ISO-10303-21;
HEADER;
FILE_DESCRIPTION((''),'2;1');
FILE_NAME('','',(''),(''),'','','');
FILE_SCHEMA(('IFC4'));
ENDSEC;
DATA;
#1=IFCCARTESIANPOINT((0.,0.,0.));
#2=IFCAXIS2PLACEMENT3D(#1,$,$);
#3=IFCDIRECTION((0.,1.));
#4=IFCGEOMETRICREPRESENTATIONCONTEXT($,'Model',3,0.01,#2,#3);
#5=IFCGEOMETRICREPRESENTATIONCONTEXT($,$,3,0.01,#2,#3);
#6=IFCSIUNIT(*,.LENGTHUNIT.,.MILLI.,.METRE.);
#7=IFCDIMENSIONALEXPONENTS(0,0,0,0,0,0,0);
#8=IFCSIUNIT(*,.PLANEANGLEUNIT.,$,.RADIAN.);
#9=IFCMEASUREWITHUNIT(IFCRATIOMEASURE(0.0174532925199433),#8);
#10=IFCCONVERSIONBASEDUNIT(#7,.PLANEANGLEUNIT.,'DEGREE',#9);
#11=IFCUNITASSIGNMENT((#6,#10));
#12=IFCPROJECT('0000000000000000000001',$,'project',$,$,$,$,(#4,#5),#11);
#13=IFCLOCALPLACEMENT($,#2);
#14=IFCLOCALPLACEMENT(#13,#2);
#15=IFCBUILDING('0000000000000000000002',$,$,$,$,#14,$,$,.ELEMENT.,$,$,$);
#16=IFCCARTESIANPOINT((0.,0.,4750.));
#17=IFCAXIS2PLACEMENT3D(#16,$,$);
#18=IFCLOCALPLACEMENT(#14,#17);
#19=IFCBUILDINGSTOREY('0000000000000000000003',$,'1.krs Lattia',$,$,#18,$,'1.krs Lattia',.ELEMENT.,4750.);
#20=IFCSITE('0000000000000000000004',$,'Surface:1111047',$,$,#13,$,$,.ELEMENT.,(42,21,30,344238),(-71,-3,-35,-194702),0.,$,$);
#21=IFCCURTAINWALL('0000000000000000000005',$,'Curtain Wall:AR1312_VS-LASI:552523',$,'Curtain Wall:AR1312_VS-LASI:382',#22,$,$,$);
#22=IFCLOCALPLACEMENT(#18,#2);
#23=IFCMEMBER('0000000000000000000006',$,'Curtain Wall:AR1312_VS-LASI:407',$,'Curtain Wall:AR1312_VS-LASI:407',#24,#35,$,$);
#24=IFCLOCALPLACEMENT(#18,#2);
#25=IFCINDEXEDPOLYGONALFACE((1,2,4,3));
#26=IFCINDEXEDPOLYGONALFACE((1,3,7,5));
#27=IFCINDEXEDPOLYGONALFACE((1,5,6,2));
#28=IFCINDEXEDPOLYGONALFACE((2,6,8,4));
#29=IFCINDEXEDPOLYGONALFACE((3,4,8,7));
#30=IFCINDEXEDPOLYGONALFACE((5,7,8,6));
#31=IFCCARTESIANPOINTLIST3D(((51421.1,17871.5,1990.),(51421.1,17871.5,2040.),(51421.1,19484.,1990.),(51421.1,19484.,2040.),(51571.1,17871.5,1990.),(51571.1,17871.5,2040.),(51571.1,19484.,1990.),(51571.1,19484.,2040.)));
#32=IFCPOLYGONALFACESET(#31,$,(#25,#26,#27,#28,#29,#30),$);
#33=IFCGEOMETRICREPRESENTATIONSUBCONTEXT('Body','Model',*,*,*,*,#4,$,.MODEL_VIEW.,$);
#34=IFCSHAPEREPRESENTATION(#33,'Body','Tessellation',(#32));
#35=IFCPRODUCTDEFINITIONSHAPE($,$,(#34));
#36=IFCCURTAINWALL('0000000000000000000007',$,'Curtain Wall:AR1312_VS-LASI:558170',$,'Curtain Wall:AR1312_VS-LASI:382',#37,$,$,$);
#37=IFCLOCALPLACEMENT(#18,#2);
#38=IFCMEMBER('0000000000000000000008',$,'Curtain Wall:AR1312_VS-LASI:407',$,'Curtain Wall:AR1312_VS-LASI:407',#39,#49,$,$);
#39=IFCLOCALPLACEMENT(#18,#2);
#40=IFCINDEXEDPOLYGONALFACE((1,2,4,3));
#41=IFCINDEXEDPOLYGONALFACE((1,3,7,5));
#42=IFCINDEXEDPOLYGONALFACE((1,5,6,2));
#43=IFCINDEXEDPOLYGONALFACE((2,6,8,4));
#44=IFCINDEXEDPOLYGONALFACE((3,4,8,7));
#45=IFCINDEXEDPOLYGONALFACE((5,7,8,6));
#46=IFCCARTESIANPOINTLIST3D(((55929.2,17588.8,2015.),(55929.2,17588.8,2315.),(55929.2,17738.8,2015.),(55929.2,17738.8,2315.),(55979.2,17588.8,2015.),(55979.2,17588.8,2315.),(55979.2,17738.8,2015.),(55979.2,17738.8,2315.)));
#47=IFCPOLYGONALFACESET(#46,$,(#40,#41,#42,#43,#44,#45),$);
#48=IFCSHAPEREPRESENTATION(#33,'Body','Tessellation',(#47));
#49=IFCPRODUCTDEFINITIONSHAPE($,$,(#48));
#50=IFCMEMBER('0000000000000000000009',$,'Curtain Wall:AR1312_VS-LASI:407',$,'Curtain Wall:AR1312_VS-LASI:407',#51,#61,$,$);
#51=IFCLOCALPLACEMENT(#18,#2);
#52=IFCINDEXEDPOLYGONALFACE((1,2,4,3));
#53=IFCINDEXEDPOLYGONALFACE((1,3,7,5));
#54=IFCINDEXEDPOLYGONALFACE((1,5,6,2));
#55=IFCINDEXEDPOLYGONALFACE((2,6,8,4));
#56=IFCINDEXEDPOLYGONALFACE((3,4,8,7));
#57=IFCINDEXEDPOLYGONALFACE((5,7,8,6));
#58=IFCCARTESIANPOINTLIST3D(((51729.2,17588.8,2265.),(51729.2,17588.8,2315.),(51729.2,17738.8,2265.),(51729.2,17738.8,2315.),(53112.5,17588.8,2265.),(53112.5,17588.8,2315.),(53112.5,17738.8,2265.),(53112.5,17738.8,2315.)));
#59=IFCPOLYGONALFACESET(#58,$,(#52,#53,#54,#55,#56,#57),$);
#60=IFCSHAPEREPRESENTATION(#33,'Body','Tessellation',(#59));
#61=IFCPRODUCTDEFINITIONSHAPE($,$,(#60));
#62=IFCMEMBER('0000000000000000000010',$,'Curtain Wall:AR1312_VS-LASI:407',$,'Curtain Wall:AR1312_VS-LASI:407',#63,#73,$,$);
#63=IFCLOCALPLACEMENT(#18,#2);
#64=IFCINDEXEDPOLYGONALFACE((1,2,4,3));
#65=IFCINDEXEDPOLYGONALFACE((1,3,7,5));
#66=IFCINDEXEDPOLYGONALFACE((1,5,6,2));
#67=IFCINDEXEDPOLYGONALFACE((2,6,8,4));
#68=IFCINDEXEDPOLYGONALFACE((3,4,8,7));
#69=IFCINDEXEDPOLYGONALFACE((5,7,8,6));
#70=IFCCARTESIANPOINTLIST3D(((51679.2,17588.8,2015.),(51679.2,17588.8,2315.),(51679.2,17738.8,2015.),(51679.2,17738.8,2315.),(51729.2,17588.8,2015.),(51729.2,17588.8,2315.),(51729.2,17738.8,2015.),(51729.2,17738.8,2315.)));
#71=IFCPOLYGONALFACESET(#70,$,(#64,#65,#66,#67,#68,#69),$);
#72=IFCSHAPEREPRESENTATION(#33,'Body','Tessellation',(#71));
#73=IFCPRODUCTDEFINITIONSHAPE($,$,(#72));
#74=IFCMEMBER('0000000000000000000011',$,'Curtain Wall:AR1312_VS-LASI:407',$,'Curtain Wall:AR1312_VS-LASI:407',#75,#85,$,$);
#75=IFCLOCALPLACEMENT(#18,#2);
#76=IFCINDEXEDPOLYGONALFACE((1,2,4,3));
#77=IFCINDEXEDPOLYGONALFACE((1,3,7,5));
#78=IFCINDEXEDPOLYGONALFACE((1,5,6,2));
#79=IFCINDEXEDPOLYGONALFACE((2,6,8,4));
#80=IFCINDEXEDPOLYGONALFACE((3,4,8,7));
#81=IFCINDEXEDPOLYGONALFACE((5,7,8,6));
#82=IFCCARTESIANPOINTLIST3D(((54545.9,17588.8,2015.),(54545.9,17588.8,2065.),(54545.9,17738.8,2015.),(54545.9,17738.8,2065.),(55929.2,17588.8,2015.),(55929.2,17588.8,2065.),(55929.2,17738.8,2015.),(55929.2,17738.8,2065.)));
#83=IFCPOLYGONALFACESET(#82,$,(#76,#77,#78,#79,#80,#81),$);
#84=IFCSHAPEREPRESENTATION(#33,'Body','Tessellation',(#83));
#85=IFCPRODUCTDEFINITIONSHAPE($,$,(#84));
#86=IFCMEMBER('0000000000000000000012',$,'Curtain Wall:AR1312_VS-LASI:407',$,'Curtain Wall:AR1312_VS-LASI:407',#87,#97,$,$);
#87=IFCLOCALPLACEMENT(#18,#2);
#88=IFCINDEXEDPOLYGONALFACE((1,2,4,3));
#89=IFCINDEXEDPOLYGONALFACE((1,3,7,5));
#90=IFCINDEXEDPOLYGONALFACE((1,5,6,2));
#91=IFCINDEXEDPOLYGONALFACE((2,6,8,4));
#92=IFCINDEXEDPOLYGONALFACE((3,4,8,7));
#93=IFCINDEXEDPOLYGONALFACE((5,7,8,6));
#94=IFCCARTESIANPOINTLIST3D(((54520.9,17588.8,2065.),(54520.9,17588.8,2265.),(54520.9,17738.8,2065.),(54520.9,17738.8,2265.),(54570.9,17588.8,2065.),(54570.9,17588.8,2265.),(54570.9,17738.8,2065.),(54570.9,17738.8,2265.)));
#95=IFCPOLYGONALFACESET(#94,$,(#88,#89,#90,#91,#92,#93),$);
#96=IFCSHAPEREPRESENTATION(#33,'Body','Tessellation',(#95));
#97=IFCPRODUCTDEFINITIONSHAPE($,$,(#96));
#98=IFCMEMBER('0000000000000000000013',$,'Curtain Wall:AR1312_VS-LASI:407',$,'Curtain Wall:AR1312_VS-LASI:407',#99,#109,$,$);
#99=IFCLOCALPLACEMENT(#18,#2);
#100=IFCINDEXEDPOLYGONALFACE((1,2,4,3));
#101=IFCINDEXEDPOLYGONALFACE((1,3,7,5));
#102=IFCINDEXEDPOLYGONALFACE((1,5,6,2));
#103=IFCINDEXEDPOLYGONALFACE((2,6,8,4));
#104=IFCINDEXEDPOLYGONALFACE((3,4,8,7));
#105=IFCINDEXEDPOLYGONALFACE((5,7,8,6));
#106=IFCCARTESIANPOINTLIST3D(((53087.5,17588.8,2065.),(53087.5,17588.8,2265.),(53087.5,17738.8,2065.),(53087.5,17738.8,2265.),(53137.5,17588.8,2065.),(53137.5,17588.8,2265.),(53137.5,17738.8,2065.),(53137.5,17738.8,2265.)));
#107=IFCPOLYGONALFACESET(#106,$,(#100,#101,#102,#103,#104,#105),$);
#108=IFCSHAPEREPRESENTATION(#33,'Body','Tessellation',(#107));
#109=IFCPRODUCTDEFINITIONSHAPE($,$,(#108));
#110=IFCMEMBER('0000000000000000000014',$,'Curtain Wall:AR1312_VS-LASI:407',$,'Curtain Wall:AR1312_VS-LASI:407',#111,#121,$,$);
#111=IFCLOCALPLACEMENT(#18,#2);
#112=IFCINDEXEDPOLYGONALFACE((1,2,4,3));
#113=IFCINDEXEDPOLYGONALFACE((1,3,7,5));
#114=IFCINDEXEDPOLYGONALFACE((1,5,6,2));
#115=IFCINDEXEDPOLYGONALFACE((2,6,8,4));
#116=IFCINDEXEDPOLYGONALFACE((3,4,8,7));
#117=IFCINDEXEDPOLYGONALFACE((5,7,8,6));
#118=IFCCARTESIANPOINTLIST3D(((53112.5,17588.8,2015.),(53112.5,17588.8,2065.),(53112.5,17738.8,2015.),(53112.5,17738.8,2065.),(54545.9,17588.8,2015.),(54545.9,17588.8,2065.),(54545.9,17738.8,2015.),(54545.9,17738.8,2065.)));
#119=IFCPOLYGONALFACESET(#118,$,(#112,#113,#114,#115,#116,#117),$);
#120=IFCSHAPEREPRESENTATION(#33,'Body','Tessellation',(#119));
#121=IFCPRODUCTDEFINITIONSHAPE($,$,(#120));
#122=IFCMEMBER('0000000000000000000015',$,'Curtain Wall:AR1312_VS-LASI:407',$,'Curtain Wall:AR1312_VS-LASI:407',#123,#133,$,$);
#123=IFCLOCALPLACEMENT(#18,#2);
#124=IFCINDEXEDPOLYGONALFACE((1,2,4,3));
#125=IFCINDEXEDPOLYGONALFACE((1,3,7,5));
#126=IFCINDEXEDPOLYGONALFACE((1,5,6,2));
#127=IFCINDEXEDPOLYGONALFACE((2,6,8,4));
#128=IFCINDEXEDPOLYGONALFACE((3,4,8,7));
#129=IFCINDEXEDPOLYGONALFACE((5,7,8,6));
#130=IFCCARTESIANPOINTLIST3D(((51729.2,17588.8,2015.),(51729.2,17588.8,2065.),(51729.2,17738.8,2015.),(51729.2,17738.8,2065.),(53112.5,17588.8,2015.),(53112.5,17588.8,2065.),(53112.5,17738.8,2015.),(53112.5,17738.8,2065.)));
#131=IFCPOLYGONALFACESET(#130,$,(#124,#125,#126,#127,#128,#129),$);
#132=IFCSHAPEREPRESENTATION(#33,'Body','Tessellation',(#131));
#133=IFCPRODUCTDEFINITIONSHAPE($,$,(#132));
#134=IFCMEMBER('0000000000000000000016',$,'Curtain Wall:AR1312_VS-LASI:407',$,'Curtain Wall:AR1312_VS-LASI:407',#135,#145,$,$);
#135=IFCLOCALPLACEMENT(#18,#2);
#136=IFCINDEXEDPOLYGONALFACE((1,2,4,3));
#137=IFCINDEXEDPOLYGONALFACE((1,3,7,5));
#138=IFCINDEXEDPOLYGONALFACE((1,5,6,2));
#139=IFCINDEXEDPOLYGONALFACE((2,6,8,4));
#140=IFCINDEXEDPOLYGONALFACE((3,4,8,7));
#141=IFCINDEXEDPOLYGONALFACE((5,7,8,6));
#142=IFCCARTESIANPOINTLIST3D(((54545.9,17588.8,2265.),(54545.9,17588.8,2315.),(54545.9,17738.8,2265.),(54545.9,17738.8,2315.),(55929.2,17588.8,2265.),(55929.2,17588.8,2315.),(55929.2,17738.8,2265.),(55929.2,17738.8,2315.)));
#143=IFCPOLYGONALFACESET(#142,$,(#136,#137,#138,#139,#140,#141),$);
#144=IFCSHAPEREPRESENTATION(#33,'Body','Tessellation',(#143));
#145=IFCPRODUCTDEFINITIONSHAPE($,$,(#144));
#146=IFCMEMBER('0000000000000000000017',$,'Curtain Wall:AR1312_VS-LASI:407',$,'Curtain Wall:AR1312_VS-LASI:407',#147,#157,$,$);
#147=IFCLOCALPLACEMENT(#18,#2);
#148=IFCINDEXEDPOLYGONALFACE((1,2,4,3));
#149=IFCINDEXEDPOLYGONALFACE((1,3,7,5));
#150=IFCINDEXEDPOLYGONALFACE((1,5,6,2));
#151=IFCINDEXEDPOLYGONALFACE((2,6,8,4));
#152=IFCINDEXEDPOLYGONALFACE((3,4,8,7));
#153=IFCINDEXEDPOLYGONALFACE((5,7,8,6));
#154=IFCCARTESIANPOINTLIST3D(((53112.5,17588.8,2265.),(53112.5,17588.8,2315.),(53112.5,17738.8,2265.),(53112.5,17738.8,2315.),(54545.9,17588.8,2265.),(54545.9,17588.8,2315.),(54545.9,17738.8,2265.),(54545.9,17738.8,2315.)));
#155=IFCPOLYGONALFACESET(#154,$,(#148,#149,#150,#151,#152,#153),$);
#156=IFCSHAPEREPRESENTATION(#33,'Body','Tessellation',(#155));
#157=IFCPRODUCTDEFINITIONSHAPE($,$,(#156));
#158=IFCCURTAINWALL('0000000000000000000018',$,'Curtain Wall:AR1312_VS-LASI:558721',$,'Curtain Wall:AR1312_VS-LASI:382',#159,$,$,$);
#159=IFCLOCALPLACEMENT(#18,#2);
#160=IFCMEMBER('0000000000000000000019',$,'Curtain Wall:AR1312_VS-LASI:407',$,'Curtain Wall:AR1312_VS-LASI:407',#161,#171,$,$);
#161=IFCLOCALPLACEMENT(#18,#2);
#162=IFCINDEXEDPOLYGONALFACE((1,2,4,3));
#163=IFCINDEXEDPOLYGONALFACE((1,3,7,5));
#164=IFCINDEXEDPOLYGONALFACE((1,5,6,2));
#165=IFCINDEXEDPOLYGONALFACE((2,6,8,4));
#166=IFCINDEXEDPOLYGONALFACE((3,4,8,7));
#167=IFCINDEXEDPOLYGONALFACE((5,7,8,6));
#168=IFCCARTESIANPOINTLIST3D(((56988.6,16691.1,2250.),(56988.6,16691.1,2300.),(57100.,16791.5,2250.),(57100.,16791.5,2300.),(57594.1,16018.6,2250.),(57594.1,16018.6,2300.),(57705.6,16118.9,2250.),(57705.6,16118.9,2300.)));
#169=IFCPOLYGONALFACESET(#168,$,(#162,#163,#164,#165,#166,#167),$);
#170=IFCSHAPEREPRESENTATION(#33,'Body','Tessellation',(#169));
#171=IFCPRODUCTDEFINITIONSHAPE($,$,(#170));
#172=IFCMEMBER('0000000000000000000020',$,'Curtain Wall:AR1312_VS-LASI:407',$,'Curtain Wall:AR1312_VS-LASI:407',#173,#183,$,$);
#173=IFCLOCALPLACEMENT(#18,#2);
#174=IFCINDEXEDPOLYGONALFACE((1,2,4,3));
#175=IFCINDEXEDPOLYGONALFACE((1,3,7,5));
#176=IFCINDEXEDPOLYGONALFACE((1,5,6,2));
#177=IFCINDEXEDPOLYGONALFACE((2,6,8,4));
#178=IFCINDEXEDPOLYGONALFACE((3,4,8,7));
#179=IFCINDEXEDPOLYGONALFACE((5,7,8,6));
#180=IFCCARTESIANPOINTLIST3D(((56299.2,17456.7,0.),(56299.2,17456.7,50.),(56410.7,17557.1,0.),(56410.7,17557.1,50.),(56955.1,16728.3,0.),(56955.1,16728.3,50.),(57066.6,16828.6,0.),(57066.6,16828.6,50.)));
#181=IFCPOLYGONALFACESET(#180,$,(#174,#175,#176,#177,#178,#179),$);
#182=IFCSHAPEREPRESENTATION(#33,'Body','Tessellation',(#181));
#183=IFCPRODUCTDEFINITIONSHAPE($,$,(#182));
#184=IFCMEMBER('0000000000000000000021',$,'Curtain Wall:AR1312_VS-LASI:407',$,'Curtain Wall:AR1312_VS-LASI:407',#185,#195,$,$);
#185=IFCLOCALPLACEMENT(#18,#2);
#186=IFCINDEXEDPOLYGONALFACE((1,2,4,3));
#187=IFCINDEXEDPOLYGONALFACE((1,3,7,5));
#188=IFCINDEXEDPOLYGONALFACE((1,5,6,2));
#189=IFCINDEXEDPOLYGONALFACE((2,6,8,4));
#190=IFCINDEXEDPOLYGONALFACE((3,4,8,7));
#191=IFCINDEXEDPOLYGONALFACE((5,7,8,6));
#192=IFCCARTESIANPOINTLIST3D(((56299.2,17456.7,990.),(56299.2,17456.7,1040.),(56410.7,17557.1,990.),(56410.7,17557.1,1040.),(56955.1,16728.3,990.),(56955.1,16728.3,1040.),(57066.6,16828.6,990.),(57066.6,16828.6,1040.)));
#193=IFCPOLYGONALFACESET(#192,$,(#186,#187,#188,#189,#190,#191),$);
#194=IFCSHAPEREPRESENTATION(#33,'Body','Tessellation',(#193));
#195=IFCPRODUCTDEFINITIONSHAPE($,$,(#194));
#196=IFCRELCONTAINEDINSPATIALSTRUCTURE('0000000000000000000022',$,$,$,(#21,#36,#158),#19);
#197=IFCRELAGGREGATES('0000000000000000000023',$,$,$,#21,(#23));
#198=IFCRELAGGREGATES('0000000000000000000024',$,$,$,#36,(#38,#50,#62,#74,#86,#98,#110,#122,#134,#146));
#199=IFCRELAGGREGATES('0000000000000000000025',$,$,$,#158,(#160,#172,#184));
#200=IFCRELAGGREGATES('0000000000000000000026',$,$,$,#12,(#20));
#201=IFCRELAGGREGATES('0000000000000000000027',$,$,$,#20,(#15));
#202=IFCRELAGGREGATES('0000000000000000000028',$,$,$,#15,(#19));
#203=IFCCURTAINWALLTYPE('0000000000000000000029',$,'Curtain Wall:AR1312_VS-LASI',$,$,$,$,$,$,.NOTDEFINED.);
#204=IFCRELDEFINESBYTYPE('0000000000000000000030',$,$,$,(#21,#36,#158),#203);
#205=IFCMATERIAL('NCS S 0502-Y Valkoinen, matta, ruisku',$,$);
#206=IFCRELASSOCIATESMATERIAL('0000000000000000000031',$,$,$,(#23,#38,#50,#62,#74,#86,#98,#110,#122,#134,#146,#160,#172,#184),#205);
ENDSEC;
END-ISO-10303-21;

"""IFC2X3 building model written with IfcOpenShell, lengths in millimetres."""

from ifc_helpers import new_model, entity, si_unit, converted_unit, direction, frame, frame_2d, origin, origin_2d_with_axis, place, context, subcontext, project, spatial, rectangle, extrude, material, type_object, element, aggregate, save


model = new_model("IFC2X3")

# Units and contexts
model_context = context("Model", 3, precision=0.01, world=origin(), true_north=direction((0.0, 1.0)))
context_of_model = context(None, 3, precision=0.01, world=origin(), true_north=direction((0.0, 1.0)))
body_context = subcontext(model_context, "Body", "Model", "MODEL_VIEW")
ifc_project = project(units=[si_unit("LENGTHUNIT", "METRE", prefix="MILLI"), converted_unit("PLANEANGLEUNIT", "DEGREE", entity("IfcRatioMeasure", 0.0174532925199433), si_unit("PLANEANGLEUNIT", "RADIAN"), dimensions=[0, 0, 0, 0, 0, 0, 0])], contexts=[model_context, context_of_model])

# Site, building, storey
site_placement = place(None, origin())
site = spatial("IfcSite", under=ifc_project, at=site_placement, Name="Surface:1111047", CompositionType="ELEMENT", RefLatitude=(42, 21, 30, 344238), RefLongitude=(-71, -3, -35, -194702), RefElevation=0.0)
building_placement = place(site_placement, origin())
building = spatial("IfcBuilding", under=site, at=building_placement, CompositionType="ELEMENT")
storey_placement = place(building_placement, frame((0.0, 0.0, 4750.0)))
storey = spatial("IfcBuildingStorey", under=building, at=storey_placement, Name="1.krs Lattia", LongName="1.krs Lattia", CompositionType="ELEMENT", Elevation=4750.0)

# Curtain wall, member
curtain_wall_type = type_object("IfcCurtainWallType", Name="Curtain Wall:AR1312_VS-LASI", PredefinedType="NOTDEFINED")
curtain_wall_1_placement = place(storey_placement, frame((0.0, 0.0, -4750.0)))
curtain_wall_1 = element("IfcCurtainWall", 1, at=curtain_wall_1_placement, inside=storey, type_object=curtain_wall_type, Name="Curtain Wall:AR1312_VS-LASI:552523", ObjectType="Curtain Wall:AR1312_VS-LASI:382")
ifc_material = material(Name="NCS S 0502-Y Valkoinen, matta, ruisku")
member_1_placement = place(curtain_wall_1_placement, frame((0.0, 0.0, 4750.0)))
member_1 = element("IfcMember", 2, at=member_1_placement, material=ifc_material, Name="Curtain Wall:AR1312_VS-LASI:407", ObjectType="Curtain Wall:AR1312_VS-LASI:407", context=body_context, shape_type="SweptSolid", body=[
    extrude(rectangle(XDim=50.0, YDim=150.0, at=frame_2d((0.0, 0.0), x_axis=(1.0, 0.0))), frame((51496.1, 19484.0, 2015.0), z_axis=(0.0, -1.0, 0.0), x_axis=(0.0, 0.0, -1.0)), (0.0, 0.0, 1.0), 1612.5),
])
aggregate(curtain_wall_1, [member_1])

# Curtain walls, members
curtain_wall_2_placement = place(storey_placement, frame((0.0, 0.0, -4750.0)))
curtain_wall_2 = element("IfcCurtainWall", 3, at=curtain_wall_2_placement, inside=storey, type_object=curtain_wall_type, Name="Curtain Wall:AR1312_VS-LASI:558170", ObjectType="Curtain Wall:AR1312_VS-LASI:382")
member_2_placement = place(curtain_wall_2_placement, frame((0.0, 0.0, 4750.0)))
member_2 = element("IfcMember", 4, at=member_2_placement, material=ifc_material, Name="Curtain Wall:AR1312_VS-LASI:407", ObjectType="Curtain Wall:AR1312_VS-LASI:407", context=body_context, shape_type="SweptSolid", body=[
    extrude(rectangle(XDim=50.0, YDim=150.0, at=frame_2d((0.0, 0.0), x_axis=(1.0, 0.0))), frame((55954.2, 17663.8, 2315.0), z_axis=(0.0, 0.0, -1.0), x_axis=(-1.0, 0.0, 0.0)), (0.0, 0.0, 1.0), 300.0),
])
member_3_placement = place(curtain_wall_2_placement, frame((0.0, 0.0, 4750.0)))
member_3 = element("IfcMember", 5, at=member_3_placement, material=ifc_material, Name="Curtain Wall:AR1312_VS-LASI:407", ObjectType="Curtain Wall:AR1312_VS-LASI:407", context=body_context, shape_type="SweptSolid", body=[
    extrude(rectangle(XDim=50.0, YDim=150.0, at=frame_2d((0.0, 0.0), x_axis=(1.0, 0.0))), frame((51729.2, 17663.8, 2290.0), z_axis=(1.0, 0.0, 0.0), x_axis=(0.0, 0.0, -1.0)), (0.0, 0.0, 1.0), 1383.3),
])
member_4_placement = place(curtain_wall_2_placement, frame((0.0, 0.0, 4750.0)))
member_4 = element("IfcMember", 6, at=member_4_placement, material=ifc_material, Name="Curtain Wall:AR1312_VS-LASI:407", ObjectType="Curtain Wall:AR1312_VS-LASI:407", context=body_context, shape_type="SweptSolid", body=[
    extrude(rectangle(XDim=50.0, YDim=150.0, at=frame_2d((0.0, 0.0), x_axis=(1.0, 0.0))), frame((51704.2, 17663.8, 2015.0), z_axis=(0.0, 0.0, 1.0), x_axis=(-1.0, 0.0, 0.0)), (0.0, 0.0, 1.0), 300.0),
])
member_5_placement = place(curtain_wall_2_placement, frame((0.0, 0.0, 4750.0)))
member_5 = element("IfcMember", 7, at=member_5_placement, material=ifc_material, Name="Curtain Wall:AR1312_VS-LASI:407", ObjectType="Curtain Wall:AR1312_VS-LASI:407", context=body_context, shape_type="SweptSolid", body=[
    extrude(rectangle(XDim=50.0, YDim=150.0, at=frame_2d((0.0, 0.0), x_axis=(1.0, 0.0))), frame((55929.2, 17663.8, 2040.0), z_axis=(-1.0, 0.0, 0.0), x_axis=(0.0, 0.0, -1.0)), (0.0, 0.0, 1.0), 1383.3),
])
member_6_placement = place(curtain_wall_2_placement, frame((0.0, 0.0, 4750.0)))
member_6 = element("IfcMember", 8, at=member_6_placement, material=ifc_material, Name="Curtain Wall:AR1312_VS-LASI:407", ObjectType="Curtain Wall:AR1312_VS-LASI:407", context=body_context, shape_type="SweptSolid", body=[
    extrude(rectangle(XDim=50.0, YDim=150.0, at=frame_2d((0.0, 0.0), x_axis=(1.0, 0.0))), frame((54545.9, 17663.8, 2065.0), z_axis=(0.0, 0.0, 1.0), x_axis=(-1.0, 0.0, 0.0)), (0.0, 0.0, 1.0), 200.0),
])
member_7_placement = place(curtain_wall_2_placement, frame((0.0, 0.0, 4750.0)))
member_7 = element("IfcMember", 9, at=member_7_placement, material=ifc_material, Name="Curtain Wall:AR1312_VS-LASI:407", ObjectType="Curtain Wall:AR1312_VS-LASI:407", context=body_context, shape_type="SweptSolid", body=[
    extrude(rectangle(XDim=50.0, YDim=150.0, at=origin_2d_with_axis()), frame((53112.5, 17663.8, 2065.0), z_axis=(0.0, 0.0, 1.0), x_axis=(-1.0, 0.0, 0.0)), (0.0, 0.0, 1.0), 200.0),
])
member_8_placement = place(curtain_wall_2_placement, frame((0.0, 0.0, 4750.0)))
member_8 = element("IfcMember", 10, at=member_8_placement, material=ifc_material, Name="Curtain Wall:AR1312_VS-LASI:407", ObjectType="Curtain Wall:AR1312_VS-LASI:407", context=body_context, shape_type="SweptSolid", body=[
    extrude(rectangle(XDim=50.0, YDim=150.0, at=frame_2d((0.0, 0.0), x_axis=(1.0, 0.0))), frame((54545.9, 17663.8, 2040.0), z_axis=(-1.0, 0.0, 0.0), x_axis=(0.0, 0.0, -1.0)), (0.0, 0.0, 1.0), 1433.3),
])
member_9_placement = place(curtain_wall_2_placement, frame((0.0, 0.0, 4750.0)))
member_9 = element("IfcMember", 11, at=member_9_placement, material=ifc_material, Name="Curtain Wall:AR1312_VS-LASI:407", ObjectType="Curtain Wall:AR1312_VS-LASI:407", context=body_context, shape_type="SweptSolid", body=[
    extrude(rectangle(XDim=50.0, YDim=150.0, at=frame_2d((0.0, 0.0), x_axis=(1.0, 0.0))), frame((53112.5, 17663.8, 2040.0), z_axis=(-1.0, 0.0, 0.0), x_axis=(0.0, 0.0, -1.0)), (0.0, 0.0, 1.0), 1383.3),
])
member_10_placement = place(curtain_wall_2_placement, frame((0.0, 0.0, 4750.0)))
member_10 = element("IfcMember", 12, at=member_10_placement, material=ifc_material, Name="Curtain Wall:AR1312_VS-LASI:407", ObjectType="Curtain Wall:AR1312_VS-LASI:407", context=body_context, shape_type="SweptSolid", body=[
    extrude(rectangle(XDim=50.0, YDim=150.0, at=frame_2d((0.0, 0.0), x_axis=(1.0, 0.0))), frame((54545.9, 17663.8, 2290.0), z_axis=(1.0, 0.0, 0.0), x_axis=(0.0, 0.0, -1.0)), (0.0, 0.0, 1.0), 1383.3),
])
member_11_placement = place(curtain_wall_2_placement, frame((0.0, 0.0, 4750.0)))
member_11 = element("IfcMember", 13, at=member_11_placement, material=ifc_material, Name="Curtain Wall:AR1312_VS-LASI:407", ObjectType="Curtain Wall:AR1312_VS-LASI:407", context=body_context, shape_type="SweptSolid", body=[
    extrude(rectangle(XDim=50.0, YDim=150.0, at=frame_2d((0.0, 0.0), x_axis=(1.0, 0.0))), frame((53112.5, 17663.8, 2290.0), z_axis=(1.0, 0.0, 0.0), x_axis=(0.0, 0.0, -1.0)), (0.0, 0.0, 1.0), 1433.3),
])
aggregate(curtain_wall_2, [member_2, member_3, member_4, member_5, member_6, member_7, member_8, member_9, member_10, member_11])
curtain_wall_3_placement = place(storey_placement, frame((0.0, 0.0, -4750.0)))
curtain_wall_3 = element("IfcCurtainWall", 14, at=curtain_wall_3_placement, inside=storey, type_object=curtain_wall_type, Name="Curtain Wall:AR1312_VS-LASI:558721", ObjectType="Curtain Wall:AR1312_VS-LASI:382")
member_12_placement = place(curtain_wall_3_placement, frame((0.0, 0.0, 4750.0)))
member_12 = element("IfcMember", 15, at=member_12_placement, material=ifc_material, Name="Curtain Wall:AR1312_VS-LASI:407", ObjectType="Curtain Wall:AR1312_VS-LASI:407", context=body_context, shape_type="SweptSolid", body=[
    extrude(rectangle(XDim=50.0, YDim=150.0, at=origin_2d_with_axis()), frame((57649.9, 16068.7, 2275.0), z_axis=(-0.669131, 0.743145, 0.0), x_axis=(0.0, 0.0, -1.0)), (0.0, 0.0, 1.0), 905.0),
])
member_13_placement = place(curtain_wall_3_placement, frame((0.0, 0.0, 4750.0)))
member_13 = element("IfcMember", 16, at=member_13_placement, material=ifc_material, Name="Curtain Wall:AR1312_VS-LASI:407", ObjectType="Curtain Wall:AR1312_VS-LASI:407", context=body_context, shape_type="SweptSolid", body=[
    extrude(rectangle(XDim=50.0, YDim=150.0, at=frame_2d((0.0, 0.0), x_axis=(1.0, 0.0))), frame((56354.9, 17506.9, 25.0), z_axis=(0.669131, -0.743145, 0.0), x_axis=(0.0, 0.0, -1.0)), (0.0, 0.0, 1.0), 980.3),
])
member_14_placement = place(curtain_wall_3_placement, frame((0.0, 0.0, 4750.0)))
member_14 = element("IfcMember", 17, at=member_14_placement, material=ifc_material, Name="Curtain Wall:AR1312_VS-LASI:407", ObjectType="Curtain Wall:AR1312_VS-LASI:407", context=body_context, shape_type="SweptSolid", body=[
    extrude(rectangle(XDim=50.0, YDim=150.0, at=origin_2d_with_axis()), frame((57010.8, 16778.4, 1015.0), z_axis=(-0.669131, 0.743145, 0.0), x_axis=(0.0, 0.0, -1.0)), (0.0, 0.0, 1.0), 980.3),
])
aggregate(curtain_wall_3, [member_12, member_13, member_14])

save(model, "model.ifc")
